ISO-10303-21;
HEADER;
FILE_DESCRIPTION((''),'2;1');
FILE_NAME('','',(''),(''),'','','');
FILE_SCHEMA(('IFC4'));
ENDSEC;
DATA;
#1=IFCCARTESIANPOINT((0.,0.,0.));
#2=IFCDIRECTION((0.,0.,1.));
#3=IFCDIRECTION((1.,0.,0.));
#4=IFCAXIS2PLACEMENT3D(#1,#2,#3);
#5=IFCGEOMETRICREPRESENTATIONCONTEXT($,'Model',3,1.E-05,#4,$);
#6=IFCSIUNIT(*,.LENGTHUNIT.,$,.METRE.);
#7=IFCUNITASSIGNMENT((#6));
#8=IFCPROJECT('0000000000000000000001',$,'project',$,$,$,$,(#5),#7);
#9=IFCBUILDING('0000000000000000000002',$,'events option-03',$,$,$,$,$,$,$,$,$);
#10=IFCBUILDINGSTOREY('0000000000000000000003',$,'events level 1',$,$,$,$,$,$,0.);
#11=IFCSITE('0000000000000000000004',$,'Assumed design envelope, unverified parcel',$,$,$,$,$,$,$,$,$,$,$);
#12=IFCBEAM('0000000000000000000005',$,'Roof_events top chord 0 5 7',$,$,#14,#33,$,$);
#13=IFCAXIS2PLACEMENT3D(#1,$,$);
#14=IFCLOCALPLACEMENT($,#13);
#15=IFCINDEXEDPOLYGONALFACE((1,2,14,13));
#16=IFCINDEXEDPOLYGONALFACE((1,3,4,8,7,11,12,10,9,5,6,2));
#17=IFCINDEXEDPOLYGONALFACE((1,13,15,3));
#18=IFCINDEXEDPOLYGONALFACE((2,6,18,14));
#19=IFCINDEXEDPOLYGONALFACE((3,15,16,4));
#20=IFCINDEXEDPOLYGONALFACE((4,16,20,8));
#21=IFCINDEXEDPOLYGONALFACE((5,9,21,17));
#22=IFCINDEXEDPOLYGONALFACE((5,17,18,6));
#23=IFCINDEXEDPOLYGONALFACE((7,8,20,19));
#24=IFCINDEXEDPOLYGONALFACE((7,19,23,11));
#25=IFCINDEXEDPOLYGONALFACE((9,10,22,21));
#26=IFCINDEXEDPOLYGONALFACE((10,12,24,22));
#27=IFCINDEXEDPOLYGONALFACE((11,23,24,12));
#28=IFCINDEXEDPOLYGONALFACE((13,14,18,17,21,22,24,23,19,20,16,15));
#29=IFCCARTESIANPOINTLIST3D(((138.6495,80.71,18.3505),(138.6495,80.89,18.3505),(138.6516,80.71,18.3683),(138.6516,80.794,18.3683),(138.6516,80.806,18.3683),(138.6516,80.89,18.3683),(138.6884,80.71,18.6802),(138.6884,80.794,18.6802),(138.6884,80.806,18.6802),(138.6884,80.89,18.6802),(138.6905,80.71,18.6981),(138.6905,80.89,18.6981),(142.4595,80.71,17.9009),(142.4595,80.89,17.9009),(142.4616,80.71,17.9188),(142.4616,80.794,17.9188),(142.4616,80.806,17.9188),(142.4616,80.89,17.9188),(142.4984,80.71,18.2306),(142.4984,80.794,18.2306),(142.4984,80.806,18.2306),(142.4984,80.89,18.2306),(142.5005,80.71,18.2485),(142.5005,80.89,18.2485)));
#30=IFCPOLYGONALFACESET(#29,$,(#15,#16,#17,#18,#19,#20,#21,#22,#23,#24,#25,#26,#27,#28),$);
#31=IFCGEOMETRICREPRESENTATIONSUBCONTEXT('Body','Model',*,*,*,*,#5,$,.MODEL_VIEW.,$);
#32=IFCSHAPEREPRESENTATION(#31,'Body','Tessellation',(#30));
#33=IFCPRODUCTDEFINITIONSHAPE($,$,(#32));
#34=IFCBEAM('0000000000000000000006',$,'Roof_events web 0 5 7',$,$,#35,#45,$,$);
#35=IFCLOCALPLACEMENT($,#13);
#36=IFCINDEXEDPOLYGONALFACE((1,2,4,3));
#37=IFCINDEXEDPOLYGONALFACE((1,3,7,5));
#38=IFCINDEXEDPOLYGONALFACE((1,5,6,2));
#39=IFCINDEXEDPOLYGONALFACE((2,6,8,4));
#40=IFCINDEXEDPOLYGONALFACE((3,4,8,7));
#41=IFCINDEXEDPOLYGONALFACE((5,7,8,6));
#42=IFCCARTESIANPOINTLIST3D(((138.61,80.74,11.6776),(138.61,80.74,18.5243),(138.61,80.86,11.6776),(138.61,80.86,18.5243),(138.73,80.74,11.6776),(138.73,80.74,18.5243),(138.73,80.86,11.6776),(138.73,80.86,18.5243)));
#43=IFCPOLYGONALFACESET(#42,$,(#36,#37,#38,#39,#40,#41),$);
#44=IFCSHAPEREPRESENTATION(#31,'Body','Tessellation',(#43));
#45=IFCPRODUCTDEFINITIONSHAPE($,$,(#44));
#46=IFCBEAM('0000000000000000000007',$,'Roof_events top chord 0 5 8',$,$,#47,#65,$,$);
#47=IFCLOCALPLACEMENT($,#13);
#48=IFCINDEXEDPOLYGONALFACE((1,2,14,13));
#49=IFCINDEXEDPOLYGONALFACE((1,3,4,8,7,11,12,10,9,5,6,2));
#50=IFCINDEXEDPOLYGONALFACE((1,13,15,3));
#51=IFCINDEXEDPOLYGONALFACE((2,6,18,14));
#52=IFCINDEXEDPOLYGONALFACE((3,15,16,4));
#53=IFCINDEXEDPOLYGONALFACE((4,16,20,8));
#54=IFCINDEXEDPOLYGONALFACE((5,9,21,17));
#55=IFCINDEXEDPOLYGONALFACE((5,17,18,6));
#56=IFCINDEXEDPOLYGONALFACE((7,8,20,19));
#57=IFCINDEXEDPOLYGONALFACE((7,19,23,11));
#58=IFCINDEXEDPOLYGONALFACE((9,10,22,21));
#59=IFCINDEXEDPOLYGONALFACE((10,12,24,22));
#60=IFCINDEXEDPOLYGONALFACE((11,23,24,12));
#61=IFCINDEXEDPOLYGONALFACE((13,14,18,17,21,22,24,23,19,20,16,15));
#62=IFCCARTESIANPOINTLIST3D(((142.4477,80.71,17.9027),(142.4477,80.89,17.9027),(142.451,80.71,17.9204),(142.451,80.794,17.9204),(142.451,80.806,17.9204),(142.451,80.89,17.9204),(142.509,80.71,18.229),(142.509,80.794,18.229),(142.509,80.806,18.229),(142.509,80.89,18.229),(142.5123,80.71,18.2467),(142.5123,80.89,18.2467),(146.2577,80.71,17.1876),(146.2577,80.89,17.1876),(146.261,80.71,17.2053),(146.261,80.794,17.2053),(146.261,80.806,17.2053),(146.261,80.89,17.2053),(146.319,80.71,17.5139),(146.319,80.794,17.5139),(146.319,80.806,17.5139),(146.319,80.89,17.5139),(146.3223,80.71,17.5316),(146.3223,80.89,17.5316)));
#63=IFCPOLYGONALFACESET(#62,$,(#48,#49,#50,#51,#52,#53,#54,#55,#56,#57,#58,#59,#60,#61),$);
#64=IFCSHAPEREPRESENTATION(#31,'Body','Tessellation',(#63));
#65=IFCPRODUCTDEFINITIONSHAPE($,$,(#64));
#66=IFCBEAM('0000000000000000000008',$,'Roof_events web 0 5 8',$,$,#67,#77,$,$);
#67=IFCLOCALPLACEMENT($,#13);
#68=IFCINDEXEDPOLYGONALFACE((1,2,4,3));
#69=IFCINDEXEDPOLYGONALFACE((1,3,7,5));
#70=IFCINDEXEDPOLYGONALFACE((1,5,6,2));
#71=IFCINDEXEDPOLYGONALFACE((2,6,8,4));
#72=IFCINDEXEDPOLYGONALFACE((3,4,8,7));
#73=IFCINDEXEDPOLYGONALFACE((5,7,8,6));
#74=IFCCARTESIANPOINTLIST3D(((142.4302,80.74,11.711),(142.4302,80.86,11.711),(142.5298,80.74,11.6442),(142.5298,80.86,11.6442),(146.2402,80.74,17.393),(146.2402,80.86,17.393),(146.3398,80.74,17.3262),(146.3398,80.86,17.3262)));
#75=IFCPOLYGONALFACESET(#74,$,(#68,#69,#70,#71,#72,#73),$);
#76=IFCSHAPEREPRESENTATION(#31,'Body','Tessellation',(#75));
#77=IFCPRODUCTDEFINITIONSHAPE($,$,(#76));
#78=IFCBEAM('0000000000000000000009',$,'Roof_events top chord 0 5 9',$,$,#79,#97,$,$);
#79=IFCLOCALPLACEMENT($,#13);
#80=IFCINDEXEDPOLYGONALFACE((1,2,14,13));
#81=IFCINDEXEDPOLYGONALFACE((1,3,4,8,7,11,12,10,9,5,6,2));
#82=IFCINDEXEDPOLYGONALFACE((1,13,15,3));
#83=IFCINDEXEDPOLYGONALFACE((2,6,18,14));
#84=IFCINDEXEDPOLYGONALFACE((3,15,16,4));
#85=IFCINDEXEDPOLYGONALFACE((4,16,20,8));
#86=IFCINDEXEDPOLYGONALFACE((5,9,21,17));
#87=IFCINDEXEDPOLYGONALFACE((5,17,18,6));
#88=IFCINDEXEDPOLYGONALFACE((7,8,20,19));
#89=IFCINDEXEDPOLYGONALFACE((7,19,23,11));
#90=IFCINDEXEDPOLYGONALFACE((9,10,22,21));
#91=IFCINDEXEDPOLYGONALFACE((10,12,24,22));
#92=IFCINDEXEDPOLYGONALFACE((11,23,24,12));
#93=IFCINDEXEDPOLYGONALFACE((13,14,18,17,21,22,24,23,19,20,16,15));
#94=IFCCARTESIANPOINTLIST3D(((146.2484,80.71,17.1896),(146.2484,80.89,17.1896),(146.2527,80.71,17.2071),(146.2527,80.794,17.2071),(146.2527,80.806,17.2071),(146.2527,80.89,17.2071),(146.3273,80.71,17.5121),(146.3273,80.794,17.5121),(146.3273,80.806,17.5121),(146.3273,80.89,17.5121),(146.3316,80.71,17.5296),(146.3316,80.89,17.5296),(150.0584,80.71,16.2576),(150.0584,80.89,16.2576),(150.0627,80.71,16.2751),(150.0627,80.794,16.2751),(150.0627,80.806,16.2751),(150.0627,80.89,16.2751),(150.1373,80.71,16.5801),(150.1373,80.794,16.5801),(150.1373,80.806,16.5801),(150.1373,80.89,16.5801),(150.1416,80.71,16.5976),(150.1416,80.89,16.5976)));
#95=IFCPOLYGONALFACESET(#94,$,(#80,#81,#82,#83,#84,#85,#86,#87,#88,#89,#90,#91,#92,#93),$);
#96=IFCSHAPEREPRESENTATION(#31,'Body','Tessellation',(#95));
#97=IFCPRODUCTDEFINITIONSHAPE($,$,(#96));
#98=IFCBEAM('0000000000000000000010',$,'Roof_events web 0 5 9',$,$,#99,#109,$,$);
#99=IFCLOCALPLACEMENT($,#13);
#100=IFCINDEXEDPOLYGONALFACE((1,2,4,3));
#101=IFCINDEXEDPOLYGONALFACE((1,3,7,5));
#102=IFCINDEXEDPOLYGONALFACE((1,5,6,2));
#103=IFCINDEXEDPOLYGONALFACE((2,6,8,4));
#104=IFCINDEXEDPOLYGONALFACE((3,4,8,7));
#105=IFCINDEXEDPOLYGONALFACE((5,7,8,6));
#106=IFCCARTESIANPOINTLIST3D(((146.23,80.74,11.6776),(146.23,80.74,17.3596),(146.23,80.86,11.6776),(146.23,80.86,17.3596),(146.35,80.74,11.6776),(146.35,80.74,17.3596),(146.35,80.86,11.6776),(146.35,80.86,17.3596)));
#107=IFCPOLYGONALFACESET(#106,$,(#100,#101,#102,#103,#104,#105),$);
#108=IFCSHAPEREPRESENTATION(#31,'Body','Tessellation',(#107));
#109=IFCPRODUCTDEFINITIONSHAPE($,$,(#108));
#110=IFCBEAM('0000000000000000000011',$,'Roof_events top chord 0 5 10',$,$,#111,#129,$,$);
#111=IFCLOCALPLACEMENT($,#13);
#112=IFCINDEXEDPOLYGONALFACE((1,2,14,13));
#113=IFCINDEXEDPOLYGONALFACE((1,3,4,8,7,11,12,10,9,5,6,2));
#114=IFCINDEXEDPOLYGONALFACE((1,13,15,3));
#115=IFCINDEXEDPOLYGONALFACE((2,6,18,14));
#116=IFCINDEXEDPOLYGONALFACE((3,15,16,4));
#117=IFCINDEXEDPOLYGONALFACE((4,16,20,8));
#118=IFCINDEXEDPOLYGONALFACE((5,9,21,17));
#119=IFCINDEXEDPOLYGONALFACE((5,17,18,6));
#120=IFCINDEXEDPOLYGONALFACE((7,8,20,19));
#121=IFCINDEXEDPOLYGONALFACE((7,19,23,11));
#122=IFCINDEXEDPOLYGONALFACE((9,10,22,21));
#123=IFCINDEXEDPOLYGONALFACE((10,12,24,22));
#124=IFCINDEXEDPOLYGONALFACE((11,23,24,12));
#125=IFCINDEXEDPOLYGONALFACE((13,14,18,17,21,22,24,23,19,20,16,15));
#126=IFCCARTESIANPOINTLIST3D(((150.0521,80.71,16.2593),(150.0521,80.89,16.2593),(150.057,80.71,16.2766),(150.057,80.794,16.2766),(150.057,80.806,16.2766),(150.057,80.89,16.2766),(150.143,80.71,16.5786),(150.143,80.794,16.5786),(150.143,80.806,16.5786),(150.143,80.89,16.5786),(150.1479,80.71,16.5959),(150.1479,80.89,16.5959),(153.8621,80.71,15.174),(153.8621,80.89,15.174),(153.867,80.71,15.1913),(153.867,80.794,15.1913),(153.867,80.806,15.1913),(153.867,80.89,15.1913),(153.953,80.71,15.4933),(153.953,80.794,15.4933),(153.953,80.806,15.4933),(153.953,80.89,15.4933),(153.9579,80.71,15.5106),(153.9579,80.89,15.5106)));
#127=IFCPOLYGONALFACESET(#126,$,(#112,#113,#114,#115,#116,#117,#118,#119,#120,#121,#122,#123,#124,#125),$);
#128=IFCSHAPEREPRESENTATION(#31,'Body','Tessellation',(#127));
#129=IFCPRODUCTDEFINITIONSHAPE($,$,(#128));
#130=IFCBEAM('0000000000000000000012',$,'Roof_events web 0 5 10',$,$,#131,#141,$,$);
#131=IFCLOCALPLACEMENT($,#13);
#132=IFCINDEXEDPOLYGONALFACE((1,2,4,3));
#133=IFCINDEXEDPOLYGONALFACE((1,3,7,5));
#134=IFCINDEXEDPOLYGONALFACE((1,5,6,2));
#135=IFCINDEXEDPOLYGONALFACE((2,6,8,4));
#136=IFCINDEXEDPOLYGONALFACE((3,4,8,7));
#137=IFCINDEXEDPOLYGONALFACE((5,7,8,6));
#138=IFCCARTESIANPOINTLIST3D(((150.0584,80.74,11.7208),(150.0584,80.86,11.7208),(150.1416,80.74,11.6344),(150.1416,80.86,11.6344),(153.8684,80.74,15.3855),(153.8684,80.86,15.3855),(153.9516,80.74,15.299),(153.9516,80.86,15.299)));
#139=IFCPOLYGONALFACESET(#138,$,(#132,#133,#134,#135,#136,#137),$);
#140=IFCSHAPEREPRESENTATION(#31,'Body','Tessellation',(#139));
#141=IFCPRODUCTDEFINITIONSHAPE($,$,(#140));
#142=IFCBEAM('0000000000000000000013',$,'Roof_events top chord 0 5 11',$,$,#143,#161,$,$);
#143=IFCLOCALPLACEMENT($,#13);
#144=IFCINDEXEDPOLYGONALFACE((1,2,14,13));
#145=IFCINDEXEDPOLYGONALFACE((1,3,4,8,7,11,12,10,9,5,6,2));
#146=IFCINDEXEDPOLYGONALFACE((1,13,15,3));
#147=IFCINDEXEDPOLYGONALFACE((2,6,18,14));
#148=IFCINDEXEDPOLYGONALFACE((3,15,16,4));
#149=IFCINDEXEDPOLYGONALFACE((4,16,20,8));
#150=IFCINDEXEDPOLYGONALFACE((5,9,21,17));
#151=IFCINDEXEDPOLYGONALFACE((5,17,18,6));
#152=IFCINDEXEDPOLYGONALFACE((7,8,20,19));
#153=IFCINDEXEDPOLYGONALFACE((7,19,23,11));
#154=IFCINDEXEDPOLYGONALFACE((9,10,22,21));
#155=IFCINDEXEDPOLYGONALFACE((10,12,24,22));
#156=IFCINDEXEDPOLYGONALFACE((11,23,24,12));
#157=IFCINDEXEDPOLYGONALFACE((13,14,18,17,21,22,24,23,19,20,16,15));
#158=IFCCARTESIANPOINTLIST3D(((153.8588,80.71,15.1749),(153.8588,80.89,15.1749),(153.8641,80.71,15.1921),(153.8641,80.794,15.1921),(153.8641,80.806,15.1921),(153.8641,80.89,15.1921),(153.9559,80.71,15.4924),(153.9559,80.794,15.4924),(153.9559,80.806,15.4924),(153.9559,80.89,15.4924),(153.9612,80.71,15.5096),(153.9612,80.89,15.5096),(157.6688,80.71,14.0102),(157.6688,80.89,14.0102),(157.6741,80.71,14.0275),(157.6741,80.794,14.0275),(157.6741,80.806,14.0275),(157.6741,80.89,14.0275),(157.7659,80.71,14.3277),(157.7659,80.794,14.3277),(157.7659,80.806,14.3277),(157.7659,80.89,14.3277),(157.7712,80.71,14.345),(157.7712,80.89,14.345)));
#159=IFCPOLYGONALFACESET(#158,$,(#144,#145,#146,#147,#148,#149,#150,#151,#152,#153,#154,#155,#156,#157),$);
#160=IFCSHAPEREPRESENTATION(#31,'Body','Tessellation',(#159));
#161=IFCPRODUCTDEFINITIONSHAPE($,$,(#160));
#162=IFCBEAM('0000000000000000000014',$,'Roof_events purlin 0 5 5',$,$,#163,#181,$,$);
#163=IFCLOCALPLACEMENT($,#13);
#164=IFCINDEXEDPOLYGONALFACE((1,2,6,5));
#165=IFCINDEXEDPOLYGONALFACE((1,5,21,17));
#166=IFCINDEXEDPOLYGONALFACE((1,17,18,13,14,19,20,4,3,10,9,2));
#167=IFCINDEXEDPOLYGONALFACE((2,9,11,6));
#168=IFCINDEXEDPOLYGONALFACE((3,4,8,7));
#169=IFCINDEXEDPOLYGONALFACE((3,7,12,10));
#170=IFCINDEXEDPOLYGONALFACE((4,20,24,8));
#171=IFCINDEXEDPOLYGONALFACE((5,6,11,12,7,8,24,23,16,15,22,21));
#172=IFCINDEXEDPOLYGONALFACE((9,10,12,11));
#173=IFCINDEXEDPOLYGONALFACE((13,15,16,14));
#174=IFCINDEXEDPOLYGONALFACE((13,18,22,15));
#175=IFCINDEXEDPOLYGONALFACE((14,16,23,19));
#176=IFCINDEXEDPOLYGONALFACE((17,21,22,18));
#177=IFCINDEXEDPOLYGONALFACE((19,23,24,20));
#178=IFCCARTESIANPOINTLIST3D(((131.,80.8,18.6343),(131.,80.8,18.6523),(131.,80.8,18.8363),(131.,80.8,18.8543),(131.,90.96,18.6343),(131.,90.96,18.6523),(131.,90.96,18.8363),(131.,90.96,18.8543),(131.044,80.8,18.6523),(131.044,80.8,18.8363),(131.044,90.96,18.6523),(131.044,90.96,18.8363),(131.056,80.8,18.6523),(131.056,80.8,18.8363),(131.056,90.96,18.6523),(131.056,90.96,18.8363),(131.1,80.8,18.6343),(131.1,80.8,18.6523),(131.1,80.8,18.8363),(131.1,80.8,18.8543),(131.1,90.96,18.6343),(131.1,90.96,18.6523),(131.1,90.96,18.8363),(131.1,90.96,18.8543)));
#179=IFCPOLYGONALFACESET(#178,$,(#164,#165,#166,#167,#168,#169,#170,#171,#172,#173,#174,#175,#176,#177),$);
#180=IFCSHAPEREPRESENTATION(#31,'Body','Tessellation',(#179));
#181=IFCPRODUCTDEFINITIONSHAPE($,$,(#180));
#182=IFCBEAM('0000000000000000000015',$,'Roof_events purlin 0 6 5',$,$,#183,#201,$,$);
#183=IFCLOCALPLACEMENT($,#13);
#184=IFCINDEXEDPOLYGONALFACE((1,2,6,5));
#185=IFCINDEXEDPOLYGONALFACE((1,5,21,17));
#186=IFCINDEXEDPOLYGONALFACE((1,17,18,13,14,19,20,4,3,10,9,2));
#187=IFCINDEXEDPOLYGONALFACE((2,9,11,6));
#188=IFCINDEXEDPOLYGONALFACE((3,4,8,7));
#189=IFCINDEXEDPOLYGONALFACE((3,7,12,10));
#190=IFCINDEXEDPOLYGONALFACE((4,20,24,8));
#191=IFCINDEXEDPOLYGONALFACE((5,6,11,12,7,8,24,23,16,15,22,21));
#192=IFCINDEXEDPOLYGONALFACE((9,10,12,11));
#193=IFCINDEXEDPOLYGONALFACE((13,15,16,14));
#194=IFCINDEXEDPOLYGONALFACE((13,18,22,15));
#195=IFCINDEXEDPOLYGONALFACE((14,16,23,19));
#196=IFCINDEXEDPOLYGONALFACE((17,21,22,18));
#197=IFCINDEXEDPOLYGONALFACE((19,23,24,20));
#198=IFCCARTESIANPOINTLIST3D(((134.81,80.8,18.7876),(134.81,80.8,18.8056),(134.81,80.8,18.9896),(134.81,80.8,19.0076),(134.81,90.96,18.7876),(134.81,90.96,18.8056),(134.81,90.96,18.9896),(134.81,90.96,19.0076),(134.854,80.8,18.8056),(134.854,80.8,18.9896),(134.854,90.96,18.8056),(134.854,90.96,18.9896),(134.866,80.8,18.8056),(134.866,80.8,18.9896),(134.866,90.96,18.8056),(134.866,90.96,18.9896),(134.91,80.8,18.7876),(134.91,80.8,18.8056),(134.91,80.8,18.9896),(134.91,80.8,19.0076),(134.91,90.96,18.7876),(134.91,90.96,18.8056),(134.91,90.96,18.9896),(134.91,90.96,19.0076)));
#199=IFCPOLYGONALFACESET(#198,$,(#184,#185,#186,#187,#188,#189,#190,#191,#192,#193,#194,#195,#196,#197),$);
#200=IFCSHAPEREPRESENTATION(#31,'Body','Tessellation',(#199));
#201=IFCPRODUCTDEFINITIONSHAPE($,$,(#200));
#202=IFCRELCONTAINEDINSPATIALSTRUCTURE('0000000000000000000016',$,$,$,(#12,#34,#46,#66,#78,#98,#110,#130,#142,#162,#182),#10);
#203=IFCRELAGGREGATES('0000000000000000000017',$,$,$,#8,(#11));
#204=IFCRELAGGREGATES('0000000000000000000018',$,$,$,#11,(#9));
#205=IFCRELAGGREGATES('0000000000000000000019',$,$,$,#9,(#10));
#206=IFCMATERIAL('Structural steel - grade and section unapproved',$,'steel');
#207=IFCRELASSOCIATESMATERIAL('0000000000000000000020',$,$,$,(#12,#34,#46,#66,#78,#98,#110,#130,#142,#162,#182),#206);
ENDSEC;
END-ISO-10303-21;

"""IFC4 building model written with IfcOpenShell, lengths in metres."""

from ifc_helpers import new_model, si_unit, frame, origin_with_axes, place, context, subcontext, project, spatial, rectangle, i_section, extrude, material, element, save


model = new_model("IFC4")

# Units and contexts
model_context = context("Model", 3, precision=1e-05, world=origin_with_axes())
body_context = subcontext(model_context, "Body", "Model", "MODEL_VIEW")
ifc_project = project(units=[si_unit("LENGTHUNIT", "METRE")], contexts=[model_context])

# Site, building, storey
site = spatial("IfcSite", under=ifc_project, Name="Assumed design envelope, unverified parcel")
building = spatial("IfcBuilding", under=site, Name="events option-03")
storey = spatial("IfcBuildingStorey", under=building, Name="events level 1", Elevation=0.0)

# Beams
ifc_material = material(Name="Structural steel - grade and section unapproved", Category="steel")
beam_1_placement = place(None, frame((138.67, 80.8, 18.5243), z_axis=(0.993111, 0.0, -0.11718), x_axis=(0.0, 1.0, 0.0)))
element("IfcBeam", 1, at=beam_1_placement, inside=storey, material=ifc_material, Name="Roof_events top chord 0 5 7", context=body_context, shape_type="SweptSolid", body=[
    extrude(i_section(OverallWidth=0.18, OverallDepth=0.35, WebThickness=0.012, FlangeThickness=0.018, FilletRadius=0.0), origin_with_axes(), (0.0, 0.0, 1.0), 3.8364),
])
beam_2_placement = place(None, frame((138.67, 80.8, 11.6776), z_axis=(0.0, 0.0, 1.0), x_axis=(-1.0, 0.0, 0.0)))
element("IfcBeam", 2, at=beam_2_placement, inside=storey, material=ifc_material, Name="Roof_events web 0 5 7", context=body_context, shape_type="SweptSolid", body=[
    extrude(rectangle(XDim=0.12, YDim=0.12), origin_with_axes(), (0.0, 0.0, 1.0), 6.8467),
])
beam_3_placement = place(None, frame((142.48, 80.8, 18.0747), z_axis=(0.982837, 0.0, -0.184478), x_axis=(0.0, 1.0, 0.0)))
element("IfcBeam", 3, at=beam_3_placement, inside=storey, material=ifc_material, Name="Roof_events top chord 0 5 8", context=body_context, shape_type="SweptSolid", body=[
    extrude(i_section(OverallWidth=0.18, OverallDepth=0.35, WebThickness=0.012, FlangeThickness=0.018, FilletRadius=0.0), origin_with_axes(), (0.0, 0.0, 1.0), 3.8765),
])
beam_4_placement = place(None, frame((142.48, 80.8, 11.6776), z_axis=(0.556926, 0.0, 0.830562), x_axis=(0.0, 1.0, 0.0)))
element("IfcBeam", 4, at=beam_4_placement, inside=storey, material=ifc_material, Name="Roof_events web 0 5 8", context=body_context, shape_type="SweptSolid", body=[
    extrude(rectangle(XDim=0.12, YDim=0.12), origin_with_axes(), (0.0, 0.0, 1.0), 6.8411),
])
beam_5_placement = place(None, frame((146.29, 80.8, 17.3596), z_axis=(0.971361, 0.0, -0.237608), x_axis=(0.0, 1.0, 0.0)))
element("IfcBeam", 5, at=beam_5_placement, inside=storey, material=ifc_material, Name="Roof_events top chord 0 5 9", context=body_context, shape_type="SweptSolid", body=[
    extrude(i_section(OverallWidth=0.18, OverallDepth=0.35, WebThickness=0.012, FlangeThickness=0.018, FilletRadius=0.0), origin_with_axes(), (0.0, 0.0, 1.0), 3.9223),
])
beam_6_placement = place(None, frame((146.29, 80.8, 11.6776), z_axis=(0.0, 0.0, 1.0), x_axis=(-1.0, 0.0, 0.0)))
element("IfcBeam", 6, at=beam_6_placement, inside=storey, material=ifc_material, Name="Roof_events web 0 5 9", context=body_context, shape_type="SweptSolid", body=[
    extrude(rectangle(XDim=0.12, YDim=0.12), origin_with_axes(), (0.0, 0.0, 1.0), 5.682),
])
beam_7_placement = place(None, frame((150.1, 80.8, 16.4276), z_axis=(0.961741, 0.0, -0.273961), x_axis=(0.0, 1.0, 0.0)))
element("IfcBeam", 7, at=beam_7_placement, inside=storey, material=ifc_material, Name="Roof_events top chord 0 5 10", context=body_context, shape_type="SweptSolid", body=[
    extrude(i_section(OverallWidth=0.18, OverallDepth=0.35, WebThickness=0.012, FlangeThickness=0.018, FilletRadius=0.0), origin_with_axes(), (0.0, 0.0, 1.0), 3.9616),
])
beam_8_placement = place(None, frame((150.1, 80.8, 11.6776), z_axis=(0.720717, 0.0, 0.693229), x_axis=(0.0, 1.0, 0.0)))
element("IfcBeam", 8, at=beam_8_placement, inside=storey, material=ifc_material, Name="Roof_events web 0 5 10", context=body_context, shape_type="SweptSolid", body=[
    extrude(rectangle(XDim=0.12, YDim=0.12), origin_with_axes(), (0.0, 0.0, 1.0), 5.2864),
])
beam_9_placement = place(None, frame((153.91, 80.8, 15.3423), z_axis=(0.956315, 0.0, -0.292338), x_axis=(0.0, 1.0, 0.0)))
element("IfcBeam", 9, at=beam_9_placement, inside=storey, material=ifc_material, Name="Roof_events top chord 0 5 11", context=body_context, shape_type="SweptSolid", body=[
    extrude(i_section(OverallWidth=0.18, OverallDepth=0.35, WebThickness=0.012, FlangeThickness=0.018, FilletRadius=0.0), origin_with_axes(), (0.0, 0.0, 1.0), 3.984),
])
for number, where, z_axis, x_axis, name in (
    (10, (131.05, 80.8, 18.7443), (0.0, 1.0, 0.0), (-1.0, 0.0, 0.0), "Roof_events purlin 0 5 5"),
    (11, (134.86, 80.8, 18.8976), (0.0, 1.0, 0.0), (-1.0, 0.0, 0.0), "Roof_events purlin 0 6 5"),
):
    element("IfcBeam", number, at=place(None, frame(where, z_axis=z_axis, x_axis=x_axis)), inside=storey, material=ifc_material, Name=name, context=body_context, shape_type="SweptSolid", body=[
        extrude(i_section(OverallWidth=0.1, OverallDepth=0.22, WebThickness=0.012, FlangeThickness=0.018, FilletRadius=0.0), origin_with_axes(), (0.0, 0.0, 1.0), 10.16),
    ])

save(model, "model.ifc")
